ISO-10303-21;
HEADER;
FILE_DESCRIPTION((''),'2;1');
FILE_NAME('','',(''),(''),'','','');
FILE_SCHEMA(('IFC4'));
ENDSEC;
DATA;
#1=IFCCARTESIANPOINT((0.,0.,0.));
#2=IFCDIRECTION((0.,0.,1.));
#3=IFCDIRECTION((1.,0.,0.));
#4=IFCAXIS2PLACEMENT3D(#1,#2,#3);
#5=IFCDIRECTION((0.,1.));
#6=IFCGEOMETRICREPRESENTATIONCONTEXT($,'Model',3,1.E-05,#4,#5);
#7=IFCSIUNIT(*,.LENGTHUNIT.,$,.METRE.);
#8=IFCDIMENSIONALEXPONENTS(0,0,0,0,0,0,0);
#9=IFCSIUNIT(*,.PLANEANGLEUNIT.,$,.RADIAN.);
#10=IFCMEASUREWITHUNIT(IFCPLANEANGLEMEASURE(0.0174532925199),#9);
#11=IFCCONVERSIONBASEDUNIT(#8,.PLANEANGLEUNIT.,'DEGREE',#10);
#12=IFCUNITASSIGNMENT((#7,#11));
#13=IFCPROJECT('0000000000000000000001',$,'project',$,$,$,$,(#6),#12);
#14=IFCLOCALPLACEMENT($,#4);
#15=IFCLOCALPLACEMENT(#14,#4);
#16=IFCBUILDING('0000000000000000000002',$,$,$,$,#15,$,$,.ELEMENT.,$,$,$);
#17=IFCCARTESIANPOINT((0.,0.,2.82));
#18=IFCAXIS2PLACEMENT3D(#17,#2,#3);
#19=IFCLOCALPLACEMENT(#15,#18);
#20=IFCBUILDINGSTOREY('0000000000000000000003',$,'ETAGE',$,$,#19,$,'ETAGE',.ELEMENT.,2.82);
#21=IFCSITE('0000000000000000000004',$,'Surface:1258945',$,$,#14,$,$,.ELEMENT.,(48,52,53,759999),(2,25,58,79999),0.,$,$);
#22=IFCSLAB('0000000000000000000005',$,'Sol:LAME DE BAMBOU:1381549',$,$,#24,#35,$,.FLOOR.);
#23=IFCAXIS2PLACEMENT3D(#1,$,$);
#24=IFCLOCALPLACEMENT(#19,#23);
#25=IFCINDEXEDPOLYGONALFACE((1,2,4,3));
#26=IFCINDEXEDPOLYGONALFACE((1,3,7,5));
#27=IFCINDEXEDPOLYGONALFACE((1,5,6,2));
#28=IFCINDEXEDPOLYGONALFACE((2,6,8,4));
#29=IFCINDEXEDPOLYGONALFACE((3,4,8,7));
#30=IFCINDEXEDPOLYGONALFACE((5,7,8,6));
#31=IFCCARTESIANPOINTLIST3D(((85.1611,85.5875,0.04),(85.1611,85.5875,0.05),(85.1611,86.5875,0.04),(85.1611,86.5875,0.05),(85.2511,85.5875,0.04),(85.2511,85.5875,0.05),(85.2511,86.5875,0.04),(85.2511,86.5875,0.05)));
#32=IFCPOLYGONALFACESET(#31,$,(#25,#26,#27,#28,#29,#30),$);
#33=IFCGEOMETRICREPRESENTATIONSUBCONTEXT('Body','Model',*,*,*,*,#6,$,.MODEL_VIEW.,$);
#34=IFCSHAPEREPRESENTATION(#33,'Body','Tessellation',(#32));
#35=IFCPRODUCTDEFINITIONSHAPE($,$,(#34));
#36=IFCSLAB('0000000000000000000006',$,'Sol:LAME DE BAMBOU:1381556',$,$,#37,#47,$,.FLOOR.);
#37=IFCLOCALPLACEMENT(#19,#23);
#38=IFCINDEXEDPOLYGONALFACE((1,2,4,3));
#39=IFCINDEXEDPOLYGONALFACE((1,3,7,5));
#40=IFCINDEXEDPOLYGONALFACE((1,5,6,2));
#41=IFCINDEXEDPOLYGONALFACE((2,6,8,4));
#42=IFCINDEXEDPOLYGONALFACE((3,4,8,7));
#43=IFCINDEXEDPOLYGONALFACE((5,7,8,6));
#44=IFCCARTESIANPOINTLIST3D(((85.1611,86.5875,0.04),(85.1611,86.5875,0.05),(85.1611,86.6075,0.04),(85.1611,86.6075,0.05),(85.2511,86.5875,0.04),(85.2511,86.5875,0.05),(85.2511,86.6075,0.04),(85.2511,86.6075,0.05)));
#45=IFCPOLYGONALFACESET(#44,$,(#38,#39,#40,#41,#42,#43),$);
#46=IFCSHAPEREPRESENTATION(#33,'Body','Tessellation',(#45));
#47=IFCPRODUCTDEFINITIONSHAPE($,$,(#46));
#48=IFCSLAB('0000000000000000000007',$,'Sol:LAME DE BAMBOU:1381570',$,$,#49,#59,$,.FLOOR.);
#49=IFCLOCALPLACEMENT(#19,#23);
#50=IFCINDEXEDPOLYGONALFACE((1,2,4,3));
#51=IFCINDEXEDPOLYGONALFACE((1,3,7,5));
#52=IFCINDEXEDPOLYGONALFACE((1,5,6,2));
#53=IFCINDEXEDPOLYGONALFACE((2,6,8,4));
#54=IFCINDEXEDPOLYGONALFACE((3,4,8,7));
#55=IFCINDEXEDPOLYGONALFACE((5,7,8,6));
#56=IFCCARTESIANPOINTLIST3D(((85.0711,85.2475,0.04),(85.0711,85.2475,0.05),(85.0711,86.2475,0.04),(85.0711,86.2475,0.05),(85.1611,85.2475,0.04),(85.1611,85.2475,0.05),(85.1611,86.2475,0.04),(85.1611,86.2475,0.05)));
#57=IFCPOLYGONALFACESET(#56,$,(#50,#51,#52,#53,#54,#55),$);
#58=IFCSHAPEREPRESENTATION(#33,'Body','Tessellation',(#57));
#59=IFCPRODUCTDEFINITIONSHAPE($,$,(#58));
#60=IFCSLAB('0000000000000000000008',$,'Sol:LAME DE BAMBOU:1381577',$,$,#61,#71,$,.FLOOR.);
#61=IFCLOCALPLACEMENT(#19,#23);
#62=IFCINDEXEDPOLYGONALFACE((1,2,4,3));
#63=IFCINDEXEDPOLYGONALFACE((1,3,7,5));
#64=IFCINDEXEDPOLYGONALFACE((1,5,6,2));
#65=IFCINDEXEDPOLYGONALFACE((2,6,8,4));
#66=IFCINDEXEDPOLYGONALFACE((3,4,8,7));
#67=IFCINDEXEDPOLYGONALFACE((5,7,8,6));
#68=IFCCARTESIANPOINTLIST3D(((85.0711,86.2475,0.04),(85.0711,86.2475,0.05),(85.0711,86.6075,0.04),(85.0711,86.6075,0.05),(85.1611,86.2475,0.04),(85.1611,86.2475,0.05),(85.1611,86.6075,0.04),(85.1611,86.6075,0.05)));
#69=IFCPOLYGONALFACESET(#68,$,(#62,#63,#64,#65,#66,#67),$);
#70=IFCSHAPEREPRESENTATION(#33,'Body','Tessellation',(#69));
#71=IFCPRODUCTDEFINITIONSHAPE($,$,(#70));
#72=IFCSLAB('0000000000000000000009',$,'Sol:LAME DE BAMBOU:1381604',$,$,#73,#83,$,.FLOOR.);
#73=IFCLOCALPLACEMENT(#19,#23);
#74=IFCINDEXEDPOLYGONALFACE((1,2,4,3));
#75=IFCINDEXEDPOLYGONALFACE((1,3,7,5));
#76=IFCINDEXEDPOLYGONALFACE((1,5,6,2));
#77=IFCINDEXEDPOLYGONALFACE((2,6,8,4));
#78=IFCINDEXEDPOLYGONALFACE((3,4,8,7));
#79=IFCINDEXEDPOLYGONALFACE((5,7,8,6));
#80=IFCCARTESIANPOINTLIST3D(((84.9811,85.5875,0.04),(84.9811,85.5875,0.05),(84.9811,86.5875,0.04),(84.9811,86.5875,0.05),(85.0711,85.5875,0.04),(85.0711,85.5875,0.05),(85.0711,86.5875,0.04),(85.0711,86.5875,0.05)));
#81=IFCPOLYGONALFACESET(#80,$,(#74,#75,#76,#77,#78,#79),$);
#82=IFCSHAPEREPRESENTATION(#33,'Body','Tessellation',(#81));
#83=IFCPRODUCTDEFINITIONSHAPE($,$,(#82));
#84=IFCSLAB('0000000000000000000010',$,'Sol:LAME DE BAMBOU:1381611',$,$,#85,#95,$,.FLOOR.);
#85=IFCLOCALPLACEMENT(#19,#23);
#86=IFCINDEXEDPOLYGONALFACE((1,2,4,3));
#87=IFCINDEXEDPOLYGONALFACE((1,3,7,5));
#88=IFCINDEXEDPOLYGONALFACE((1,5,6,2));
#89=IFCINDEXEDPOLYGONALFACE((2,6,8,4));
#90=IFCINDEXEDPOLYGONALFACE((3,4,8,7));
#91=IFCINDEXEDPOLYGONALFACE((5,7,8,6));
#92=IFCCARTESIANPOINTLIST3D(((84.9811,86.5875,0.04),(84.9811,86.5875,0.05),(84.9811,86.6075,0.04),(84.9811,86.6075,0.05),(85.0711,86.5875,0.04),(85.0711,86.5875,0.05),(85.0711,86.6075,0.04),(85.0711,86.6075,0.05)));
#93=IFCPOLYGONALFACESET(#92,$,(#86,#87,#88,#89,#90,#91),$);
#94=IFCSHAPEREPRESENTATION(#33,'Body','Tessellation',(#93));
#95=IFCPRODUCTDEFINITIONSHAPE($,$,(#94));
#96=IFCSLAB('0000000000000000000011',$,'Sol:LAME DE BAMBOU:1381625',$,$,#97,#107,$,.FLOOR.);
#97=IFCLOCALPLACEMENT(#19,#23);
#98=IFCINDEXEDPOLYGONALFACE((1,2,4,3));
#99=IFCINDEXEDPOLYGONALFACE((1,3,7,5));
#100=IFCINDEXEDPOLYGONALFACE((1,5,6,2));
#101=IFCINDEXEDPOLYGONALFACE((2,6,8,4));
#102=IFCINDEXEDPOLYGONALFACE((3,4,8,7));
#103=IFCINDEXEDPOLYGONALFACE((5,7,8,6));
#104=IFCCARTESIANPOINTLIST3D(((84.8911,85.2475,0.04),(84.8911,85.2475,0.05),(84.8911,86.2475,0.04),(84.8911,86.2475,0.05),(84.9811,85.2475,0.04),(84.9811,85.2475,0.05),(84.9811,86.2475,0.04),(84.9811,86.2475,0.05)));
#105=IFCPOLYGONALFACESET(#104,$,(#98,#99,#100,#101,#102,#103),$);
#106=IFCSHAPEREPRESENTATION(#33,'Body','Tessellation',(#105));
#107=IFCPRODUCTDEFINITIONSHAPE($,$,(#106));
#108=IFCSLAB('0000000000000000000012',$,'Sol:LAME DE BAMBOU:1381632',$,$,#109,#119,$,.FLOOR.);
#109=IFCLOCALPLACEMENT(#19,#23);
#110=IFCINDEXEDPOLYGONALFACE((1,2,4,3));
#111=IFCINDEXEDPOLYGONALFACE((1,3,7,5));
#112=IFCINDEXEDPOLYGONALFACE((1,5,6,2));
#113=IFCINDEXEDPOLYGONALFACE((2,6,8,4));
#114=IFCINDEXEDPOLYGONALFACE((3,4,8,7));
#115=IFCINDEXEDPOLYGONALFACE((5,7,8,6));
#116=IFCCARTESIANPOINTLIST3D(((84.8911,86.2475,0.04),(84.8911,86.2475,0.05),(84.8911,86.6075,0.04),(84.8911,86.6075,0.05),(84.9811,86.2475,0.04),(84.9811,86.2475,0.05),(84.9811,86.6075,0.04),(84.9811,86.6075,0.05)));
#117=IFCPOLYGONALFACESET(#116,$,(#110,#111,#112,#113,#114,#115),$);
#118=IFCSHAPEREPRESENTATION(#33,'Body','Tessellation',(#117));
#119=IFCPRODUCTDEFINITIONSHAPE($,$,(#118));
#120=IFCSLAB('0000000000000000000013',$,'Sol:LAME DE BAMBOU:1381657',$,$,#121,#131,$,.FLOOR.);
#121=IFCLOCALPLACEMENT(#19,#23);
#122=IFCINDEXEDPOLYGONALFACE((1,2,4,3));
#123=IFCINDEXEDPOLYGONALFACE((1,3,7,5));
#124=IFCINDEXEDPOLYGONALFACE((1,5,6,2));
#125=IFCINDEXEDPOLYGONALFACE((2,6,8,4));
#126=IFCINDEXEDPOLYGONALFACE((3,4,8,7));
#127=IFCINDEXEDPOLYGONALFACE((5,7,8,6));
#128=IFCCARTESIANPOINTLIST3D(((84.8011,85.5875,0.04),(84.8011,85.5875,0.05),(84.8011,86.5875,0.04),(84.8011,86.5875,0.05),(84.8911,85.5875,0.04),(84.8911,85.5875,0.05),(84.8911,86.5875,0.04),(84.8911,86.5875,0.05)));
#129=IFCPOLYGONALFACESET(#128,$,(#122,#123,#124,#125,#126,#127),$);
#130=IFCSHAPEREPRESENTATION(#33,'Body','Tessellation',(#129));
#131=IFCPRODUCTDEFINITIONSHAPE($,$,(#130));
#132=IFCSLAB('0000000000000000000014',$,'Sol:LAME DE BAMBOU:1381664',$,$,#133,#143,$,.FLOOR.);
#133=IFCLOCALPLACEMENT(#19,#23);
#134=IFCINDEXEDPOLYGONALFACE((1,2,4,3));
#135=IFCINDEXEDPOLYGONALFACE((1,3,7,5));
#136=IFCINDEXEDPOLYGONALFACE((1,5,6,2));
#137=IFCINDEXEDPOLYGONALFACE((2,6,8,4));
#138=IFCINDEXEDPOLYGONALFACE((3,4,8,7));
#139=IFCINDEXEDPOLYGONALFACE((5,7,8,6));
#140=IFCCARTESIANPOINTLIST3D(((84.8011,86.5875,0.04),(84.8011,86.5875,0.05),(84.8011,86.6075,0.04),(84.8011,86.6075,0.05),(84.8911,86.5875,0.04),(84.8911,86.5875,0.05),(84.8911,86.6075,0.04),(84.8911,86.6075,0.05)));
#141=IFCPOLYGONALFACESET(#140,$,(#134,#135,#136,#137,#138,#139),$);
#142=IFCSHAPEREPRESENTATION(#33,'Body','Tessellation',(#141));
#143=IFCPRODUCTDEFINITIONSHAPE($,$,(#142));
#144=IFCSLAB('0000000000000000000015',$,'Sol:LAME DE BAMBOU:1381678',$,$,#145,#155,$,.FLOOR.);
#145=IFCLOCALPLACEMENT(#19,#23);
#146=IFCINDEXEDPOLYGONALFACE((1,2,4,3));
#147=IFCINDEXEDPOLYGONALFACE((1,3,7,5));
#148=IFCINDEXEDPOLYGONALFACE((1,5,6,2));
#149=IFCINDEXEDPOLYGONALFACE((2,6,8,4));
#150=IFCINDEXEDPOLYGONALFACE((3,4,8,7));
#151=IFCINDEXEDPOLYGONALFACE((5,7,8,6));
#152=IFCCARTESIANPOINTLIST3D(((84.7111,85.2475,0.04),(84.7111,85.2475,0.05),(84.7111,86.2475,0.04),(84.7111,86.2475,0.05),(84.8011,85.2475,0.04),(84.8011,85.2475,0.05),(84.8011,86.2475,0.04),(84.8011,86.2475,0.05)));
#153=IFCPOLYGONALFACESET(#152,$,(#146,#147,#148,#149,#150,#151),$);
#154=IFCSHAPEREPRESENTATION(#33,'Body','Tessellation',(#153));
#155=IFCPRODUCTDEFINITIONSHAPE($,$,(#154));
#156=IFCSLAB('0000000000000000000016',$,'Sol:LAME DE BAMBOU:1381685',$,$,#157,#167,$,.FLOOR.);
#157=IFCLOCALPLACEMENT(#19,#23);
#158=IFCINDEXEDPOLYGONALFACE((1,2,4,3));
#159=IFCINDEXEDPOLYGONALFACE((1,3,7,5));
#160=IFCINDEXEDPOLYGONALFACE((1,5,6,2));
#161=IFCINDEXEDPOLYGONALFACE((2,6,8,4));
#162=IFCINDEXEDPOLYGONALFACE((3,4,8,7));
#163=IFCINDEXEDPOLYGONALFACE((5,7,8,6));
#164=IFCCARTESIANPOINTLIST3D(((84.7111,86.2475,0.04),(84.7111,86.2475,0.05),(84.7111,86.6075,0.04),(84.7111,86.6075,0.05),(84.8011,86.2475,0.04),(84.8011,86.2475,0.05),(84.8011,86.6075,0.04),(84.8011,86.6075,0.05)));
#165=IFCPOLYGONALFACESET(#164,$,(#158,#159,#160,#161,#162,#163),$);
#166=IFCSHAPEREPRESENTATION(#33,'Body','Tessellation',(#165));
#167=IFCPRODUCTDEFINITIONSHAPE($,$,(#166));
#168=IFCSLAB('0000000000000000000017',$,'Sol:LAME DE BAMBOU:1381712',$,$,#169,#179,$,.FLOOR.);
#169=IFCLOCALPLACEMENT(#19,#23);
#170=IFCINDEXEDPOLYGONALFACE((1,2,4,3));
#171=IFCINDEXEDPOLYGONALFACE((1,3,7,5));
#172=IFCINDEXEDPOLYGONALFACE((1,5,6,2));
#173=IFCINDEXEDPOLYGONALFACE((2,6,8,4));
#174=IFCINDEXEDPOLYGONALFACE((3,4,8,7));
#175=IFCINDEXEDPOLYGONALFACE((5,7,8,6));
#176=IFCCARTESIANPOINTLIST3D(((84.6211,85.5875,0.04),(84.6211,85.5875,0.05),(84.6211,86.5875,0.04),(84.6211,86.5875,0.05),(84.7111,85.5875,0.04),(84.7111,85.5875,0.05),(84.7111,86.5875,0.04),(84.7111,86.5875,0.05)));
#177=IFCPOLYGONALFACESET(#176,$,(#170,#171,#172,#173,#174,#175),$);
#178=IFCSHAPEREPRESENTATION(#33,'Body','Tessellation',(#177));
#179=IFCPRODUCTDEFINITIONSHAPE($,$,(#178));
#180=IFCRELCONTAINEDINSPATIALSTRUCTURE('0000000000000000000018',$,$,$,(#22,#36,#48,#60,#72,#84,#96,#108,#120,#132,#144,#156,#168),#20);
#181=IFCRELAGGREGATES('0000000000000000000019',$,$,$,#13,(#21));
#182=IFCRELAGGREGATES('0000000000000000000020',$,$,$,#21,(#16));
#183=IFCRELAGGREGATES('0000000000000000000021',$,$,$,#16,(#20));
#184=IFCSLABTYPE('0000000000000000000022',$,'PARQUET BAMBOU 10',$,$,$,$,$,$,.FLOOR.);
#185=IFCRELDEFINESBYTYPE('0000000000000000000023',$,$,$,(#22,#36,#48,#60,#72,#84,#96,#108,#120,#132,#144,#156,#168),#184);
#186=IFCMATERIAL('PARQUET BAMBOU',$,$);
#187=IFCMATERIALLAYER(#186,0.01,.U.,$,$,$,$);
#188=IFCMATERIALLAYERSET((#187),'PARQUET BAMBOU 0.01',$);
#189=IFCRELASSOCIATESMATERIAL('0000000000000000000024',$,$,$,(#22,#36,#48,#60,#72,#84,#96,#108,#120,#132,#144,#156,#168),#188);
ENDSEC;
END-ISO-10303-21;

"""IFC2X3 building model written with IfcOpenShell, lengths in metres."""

from ifc_helpers import new_model, entity, si_unit, converted_unit, direction, frame, origin_with_axes, place, context, subcontext, project, spatial, polyline, outline, extrude, material, layer, layer_set, layer_usage, type_object, element, save


model = new_model("IFC2X3")

# Units and contexts
model_context = context("Model", 3, precision=1e-05, world=origin_with_axes(), true_north=direction((0.0, 1.0)))
body_context = subcontext(model_context, "Body", "Model", "MODEL_VIEW")
ifc_project = project(units=[si_unit("LENGTHUNIT", "METRE"), converted_unit("PLANEANGLEUNIT", "DEGREE", entity("IfcPlaneAngleMeasure", 0.0174532925199), si_unit("PLANEANGLEUNIT", "RADIAN"), dimensions=[0, 0, 0, 0, 0, 0, 0])], contexts=[model_context])

# Site, building, storey
site_placement = place(None, origin_with_axes())
site = spatial("IfcSite", under=ifc_project, at=site_placement, Name="Surface:1258945", CompositionType="ELEMENT", RefLatitude=(48, 52, 53, 759999), RefLongitude=(2, 25, 58, 79999), RefElevation=0.0)
building_placement = place(site_placement, origin_with_axes())
building = spatial("IfcBuilding", under=site, at=building_placement, CompositionType="ELEMENT")
storey_placement = place(building_placement, frame((0.0, 0.0, 2.82), z_axis=(0.0, 0.0, 1.0), x_axis=(1.0, 0.0, 0.0)))
storey = spatial("IfcBuildingStorey", under=building, at=storey_placement, Name="ETAGE", LongName="ETAGE", CompositionType="ELEMENT", Elevation=2.82)

# Slabs
ifc_material_1 = material(Name="PARQUET BAMBOU")
ifc_layer_1 = layer(ifc_material_1, 0.01, ventilated="UNKNOWN")
ifc_layer_set_1 = layer_set([ifc_layer_1], Name="PARQUET BAMBOU 0.01")
ifc_layer_usage_1 = layer_usage(ifc_layer_set_1, "AXIS3", "NEGATIVE", 0.01)
slab_type = type_object("IfcSlabType", Name="PARQUET BAMBOU 10", PredefinedType="FLOOR")
slab_1_placement = place(storey_placement, frame((85.1611, 86.5875, 0.05), z_axis=(0.0, 0.0, 1.0), x_axis=(1.0, 0.0, 0.0)))
element("IfcSlab", 1, at=slab_1_placement, inside=storey, type_object=slab_type, material=ifc_layer_usage_1, Name="Sol:LAME DE BAMBOU:1381549", PredefinedType="FLOOR", context=body_context, shape_type="SweptSolid", body=[
    extrude(outline(polyline([(0.0, 0.0), (0.0, -1.0), (0.09, -1.0), (0.09, 0.0), (0.0, 0.0)])), frame((0.0, 0.0, -0.01), z_axis=(0.0, 0.0, 1.0), x_axis=(1.0, 0.0, 0.0)), (0.0, 0.0, 1.0), 0.01),
])
ifc_layer_usage_2 = layer_usage(ifc_layer_set_1, "AXIS3", "NEGATIVE", 0.01)
slab_2_placement = place(storey_placement, frame((85.1611, 86.6075, 0.05), z_axis=(0.0, 0.0, 1.0), x_axis=(1.0, 0.0, 0.0)))
element("IfcSlab", 2, at=slab_2_placement, inside=storey, type_object=slab_type, material=ifc_layer_usage_2, Name="Sol:LAME DE BAMBOU:1381556", PredefinedType="FLOOR", context=body_context, shape_type="SweptSolid", body=[
    extrude(outline(polyline([(0.0, 0.0), (0.0, -0.02), (0.09, -0.02), (0.09, 0.0), (0.0, 0.0)])), frame((0.0, 0.0, -0.01), z_axis=(0.0, 0.0, 1.0), x_axis=(1.0, 0.0, 0.0)), (0.0, 0.0, 1.0), 0.01),
])
ifc_layer_usage_3 = layer_usage(ifc_layer_set_1, "AXIS3", "NEGATIVE", 0.01)
slab_3_placement = place(storey_placement, frame((85.0711, 86.2475, 0.05), z_axis=(0.0, 0.0, 1.0), x_axis=(1.0, 0.0, 0.0)))
element("IfcSlab", 3, at=slab_3_placement, inside=storey, type_object=slab_type, material=ifc_layer_usage_3, Name="Sol:LAME DE BAMBOU:1381570", PredefinedType="FLOOR", context=body_context, shape_type="SweptSolid", body=[
    extrude(outline(polyline([(0.0, 0.0), (0.0, -1.0), (0.09, -1.0), (0.09, 0.0), (0.0, 0.0)])), frame((0.0, 0.0, -0.01), z_axis=(0.0, 0.0, 1.0), x_axis=(1.0, 0.0, 0.0)), (0.0, 0.0, 1.0), 0.01),
])
ifc_layer_usage_4 = layer_usage(ifc_layer_set_1, "AXIS3", "NEGATIVE", 0.01)
slab_4_placement = place(storey_placement, frame((85.0711, 86.6075, 0.05), z_axis=(0.0, 0.0, 1.0), x_axis=(1.0, 0.0, 0.0)))
element("IfcSlab", 4, at=slab_4_placement, inside=storey, type_object=slab_type, material=ifc_layer_usage_4, Name="Sol:LAME DE BAMBOU:1381577", PredefinedType="FLOOR", context=body_context, shape_type="SweptSolid", body=[
    extrude(outline(polyline([(0.0, 0.0), (0.0, -0.36), (0.09, -0.36), (0.09, 0.0), (0.0, 0.0)])), frame((0.0, 0.0, -0.01), z_axis=(0.0, 0.0, 1.0), x_axis=(1.0, 0.0, 0.0)), (0.0, 0.0, 1.0), 0.01),
])
ifc_layer_usage_5 = layer_usage(ifc_layer_set_1, "AXIS3", "NEGATIVE", 0.01)
slab_5_placement = place(storey_placement, frame((84.9811, 86.5875, 0.05), z_axis=(0.0, 0.0, 1.0), x_axis=(1.0, 0.0, 0.0)))
element("IfcSlab", 5, at=slab_5_placement, inside=storey, type_object=slab_type, material=ifc_layer_usage_5, Name="Sol:LAME DE BAMBOU:1381604", PredefinedType="FLOOR", context=body_context, shape_type="SweptSolid", body=[
    extrude(outline(polyline([(0.0, 0.0), (0.0, -1.0), (0.09, -1.0), (0.09, 0.0), (0.0, 0.0)])), frame((0.0, 0.0, -0.01), z_axis=(0.0, 0.0, 1.0), x_axis=(1.0, 0.0, 0.0)), (0.0, 0.0, 1.0), 0.01),
])
ifc_layer_usage_6 = layer_usage(ifc_layer_set_1, "AXIS3", "NEGATIVE", 0.01)
slab_6_placement = place(storey_placement, frame((84.9811, 86.6075, 0.05), z_axis=(0.0, 0.0, 1.0), x_axis=(1.0, 0.0, 0.0)))
element("IfcSlab", 6, at=slab_6_placement, inside=storey, type_object=slab_type, material=ifc_layer_usage_6, Name="Sol:LAME DE BAMBOU:1381611", PredefinedType="FLOOR", context=body_context, shape_type="SweptSolid", body=[
    extrude(outline(polyline([(0.0, 0.0), (0.0, -0.02), (0.09, -0.02), (0.09, 0.0), (0.0, 0.0)])), frame((0.0, 0.0, -0.01), z_axis=(0.0, 0.0, 1.0), x_axis=(1.0, 0.0, 0.0)), (0.0, 0.0, 1.0), 0.01),
])
ifc_layer_usage_7 = layer_usage(ifc_layer_set_1, "AXIS3", "NEGATIVE", 0.01)
slab_7_placement = place(storey_placement, frame((84.8911, 86.2475, 0.05), z_axis=(0.0, 0.0, 1.0), x_axis=(1.0, 0.0, 0.0)))
element("IfcSlab", 7, at=slab_7_placement, inside=storey, type_object=slab_type, material=ifc_layer_usage_7, Name="Sol:LAME DE BAMBOU:1381625", PredefinedType="FLOOR", context=body_context, shape_type="SweptSolid", body=[
    extrude(outline(polyline([(0.0, 0.0), (0.0, -1.0), (0.09, -1.0), (0.09, 0.0), (0.0, 0.0)])), frame((0.0, 0.0, -0.01), z_axis=(0.0, 0.0, 1.0), x_axis=(1.0, 0.0, 0.0)), (0.0, 0.0, 1.0), 0.01),
])
ifc_layer_usage_8 = layer_usage(ifc_layer_set_1, "AXIS3", "NEGATIVE", 0.01)
slab_8_placement = place(storey_placement, frame((84.8911, 86.6075, 0.05), z_axis=(0.0, 0.0, 1.0), x_axis=(1.0, 0.0, 0.0)))
element("IfcSlab", 8, at=slab_8_placement, inside=storey, type_object=slab_type, material=ifc_layer_usage_8, Name="Sol:LAME DE BAMBOU:1381632", PredefinedType="FLOOR", context=body_context, shape_type="SweptSolid", body=[
    extrude(outline(polyline([(0.0, 0.0), (0.0, -0.36), (0.09, -0.36), (0.09, 0.0), (0.0, 0.0)])), frame((0.0, 0.0, -0.01), z_axis=(0.0, 0.0, 1.0), x_axis=(1.0, 0.0, 0.0)), (0.0, 0.0, 1.0), 0.01),
])
ifc_layer_usage_9 = layer_usage(ifc_layer_set_1, "AXIS3", "NEGATIVE", 0.01)
slab_9_placement = place(storey_placement, frame((84.8011, 86.5875, 0.05), z_axis=(0.0, 0.0, 1.0), x_axis=(1.0, 0.0, 0.0)))
element("IfcSlab", 9, at=slab_9_placement, inside=storey, type_object=slab_type, material=ifc_layer_usage_9, Name="Sol:LAME DE BAMBOU:1381657", PredefinedType="FLOOR", context=body_context, shape_type="SweptSolid", body=[
    extrude(outline(polyline([(0.0, 0.0), (0.0, -1.0), (0.09, -1.0), (0.09, 0.0), (0.0, 0.0)])), frame((0.0, 0.0, -0.01), z_axis=(0.0, 0.0, 1.0), x_axis=(1.0, 0.0, 0.0)), (0.0, 0.0, 1.0), 0.01),
])
ifc_layer_usage_10 = layer_usage(ifc_layer_set_1, "AXIS3", "NEGATIVE", 0.01)
slab_10_placement = place(storey_placement, frame((84.8011, 86.6075, 0.05), z_axis=(0.0, 0.0, 1.0), x_axis=(1.0, 0.0, 0.0)))
element("IfcSlab", 10, at=slab_10_placement, inside=storey, type_object=slab_type, material=ifc_layer_usage_10, Name="Sol:LAME DE BAMBOU:1381664", PredefinedType="FLOOR", context=body_context, shape_type="SweptSolid", body=[
    extrude(outline(polyline([(0.0, 0.0), (0.0, -0.02), (0.09, -0.02), (0.09, 0.0), (0.0, 0.0)])), frame((0.0, 0.0, -0.01), z_axis=(0.0, 0.0, 1.0), x_axis=(1.0, 0.0, 0.0)), (0.0, 0.0, 1.0), 0.01),
])
ifc_layer_usage_11 = layer_usage(ifc_layer_set_1, "AXIS3", "NEGATIVE", 0.01)
slab_11_placement = place(storey_placement, frame((84.7111, 86.2475, 0.05), z_axis=(0.0, 0.0, 1.0), x_axis=(1.0, 0.0, 0.0)))
element("IfcSlab", 11, at=slab_11_placement, inside=storey, type_object=slab_type, material=ifc_layer_usage_11, Name="Sol:LAME DE BAMBOU:1381678", PredefinedType="FLOOR", context=body_context, shape_type="SweptSolid", body=[
    extrude(outline(polyline([(0.0, 0.0), (0.0, -1.0), (0.09, -1.0), (0.09, 0.0), (0.0, 0.0)])), frame((0.0, 0.0, -0.01), z_axis=(0.0, 0.0, 1.0), x_axis=(1.0, 0.0, 0.0)), (0.0, 0.0, 1.0), 0.01),
])
ifc_layer_usage_12 = layer_usage(ifc_layer_set_1, "AXIS3", "NEGATIVE", 0.01)
slab_12_placement = place(storey_placement, frame((84.7111, 86.6075, 0.05), z_axis=(0.0, 0.0, 1.0), x_axis=(1.0, 0.0, 0.0)))
element("IfcSlab", 12, at=slab_12_placement, inside=storey, type_object=slab_type, material=ifc_layer_usage_12, Name="Sol:LAME DE BAMBOU:1381685", PredefinedType="FLOOR", context=body_context, shape_type="SweptSolid", body=[
    extrude(outline(polyline([(0.0, 0.0), (0.0, -0.36), (0.09, -0.36), (0.09, 0.0), (0.0, 0.0)])), frame((0.0, 0.0, -0.01), z_axis=(0.0, 0.0, 1.0), x_axis=(1.0, 0.0, 0.0)), (0.0, 0.0, 1.0), 0.01),
])
ifc_layer_usage_13 = layer_usage(ifc_layer_set_1, "AXIS3", "NEGATIVE", 0.01)
slab_13_placement = place(storey_placement, frame((84.6211, 86.5875, 0.05), z_axis=(0.0, 0.0, 1.0), x_axis=(1.0, 0.0, 0.0)))
element("IfcSlab", 13, at=slab_13_placement, inside=storey, type_object=slab_type, material=ifc_layer_usage_13, Name="Sol:LAME DE BAMBOU:1381712", PredefinedType="FLOOR", context=body_context, shape_type="SweptSolid", body=[
    extrude(outline(polyline([(0.0, 0.0), (0.0, -1.0), (0.09, -1.0), (0.09, 0.0), (0.0, 0.0)])), frame((0.0, 0.0, -0.01), z_axis=(0.0, 0.0, 1.0), x_axis=(1.0, 0.0, 0.0)), (0.0, 0.0, 1.0), 0.01),
])

save(model, "model.ifc")
